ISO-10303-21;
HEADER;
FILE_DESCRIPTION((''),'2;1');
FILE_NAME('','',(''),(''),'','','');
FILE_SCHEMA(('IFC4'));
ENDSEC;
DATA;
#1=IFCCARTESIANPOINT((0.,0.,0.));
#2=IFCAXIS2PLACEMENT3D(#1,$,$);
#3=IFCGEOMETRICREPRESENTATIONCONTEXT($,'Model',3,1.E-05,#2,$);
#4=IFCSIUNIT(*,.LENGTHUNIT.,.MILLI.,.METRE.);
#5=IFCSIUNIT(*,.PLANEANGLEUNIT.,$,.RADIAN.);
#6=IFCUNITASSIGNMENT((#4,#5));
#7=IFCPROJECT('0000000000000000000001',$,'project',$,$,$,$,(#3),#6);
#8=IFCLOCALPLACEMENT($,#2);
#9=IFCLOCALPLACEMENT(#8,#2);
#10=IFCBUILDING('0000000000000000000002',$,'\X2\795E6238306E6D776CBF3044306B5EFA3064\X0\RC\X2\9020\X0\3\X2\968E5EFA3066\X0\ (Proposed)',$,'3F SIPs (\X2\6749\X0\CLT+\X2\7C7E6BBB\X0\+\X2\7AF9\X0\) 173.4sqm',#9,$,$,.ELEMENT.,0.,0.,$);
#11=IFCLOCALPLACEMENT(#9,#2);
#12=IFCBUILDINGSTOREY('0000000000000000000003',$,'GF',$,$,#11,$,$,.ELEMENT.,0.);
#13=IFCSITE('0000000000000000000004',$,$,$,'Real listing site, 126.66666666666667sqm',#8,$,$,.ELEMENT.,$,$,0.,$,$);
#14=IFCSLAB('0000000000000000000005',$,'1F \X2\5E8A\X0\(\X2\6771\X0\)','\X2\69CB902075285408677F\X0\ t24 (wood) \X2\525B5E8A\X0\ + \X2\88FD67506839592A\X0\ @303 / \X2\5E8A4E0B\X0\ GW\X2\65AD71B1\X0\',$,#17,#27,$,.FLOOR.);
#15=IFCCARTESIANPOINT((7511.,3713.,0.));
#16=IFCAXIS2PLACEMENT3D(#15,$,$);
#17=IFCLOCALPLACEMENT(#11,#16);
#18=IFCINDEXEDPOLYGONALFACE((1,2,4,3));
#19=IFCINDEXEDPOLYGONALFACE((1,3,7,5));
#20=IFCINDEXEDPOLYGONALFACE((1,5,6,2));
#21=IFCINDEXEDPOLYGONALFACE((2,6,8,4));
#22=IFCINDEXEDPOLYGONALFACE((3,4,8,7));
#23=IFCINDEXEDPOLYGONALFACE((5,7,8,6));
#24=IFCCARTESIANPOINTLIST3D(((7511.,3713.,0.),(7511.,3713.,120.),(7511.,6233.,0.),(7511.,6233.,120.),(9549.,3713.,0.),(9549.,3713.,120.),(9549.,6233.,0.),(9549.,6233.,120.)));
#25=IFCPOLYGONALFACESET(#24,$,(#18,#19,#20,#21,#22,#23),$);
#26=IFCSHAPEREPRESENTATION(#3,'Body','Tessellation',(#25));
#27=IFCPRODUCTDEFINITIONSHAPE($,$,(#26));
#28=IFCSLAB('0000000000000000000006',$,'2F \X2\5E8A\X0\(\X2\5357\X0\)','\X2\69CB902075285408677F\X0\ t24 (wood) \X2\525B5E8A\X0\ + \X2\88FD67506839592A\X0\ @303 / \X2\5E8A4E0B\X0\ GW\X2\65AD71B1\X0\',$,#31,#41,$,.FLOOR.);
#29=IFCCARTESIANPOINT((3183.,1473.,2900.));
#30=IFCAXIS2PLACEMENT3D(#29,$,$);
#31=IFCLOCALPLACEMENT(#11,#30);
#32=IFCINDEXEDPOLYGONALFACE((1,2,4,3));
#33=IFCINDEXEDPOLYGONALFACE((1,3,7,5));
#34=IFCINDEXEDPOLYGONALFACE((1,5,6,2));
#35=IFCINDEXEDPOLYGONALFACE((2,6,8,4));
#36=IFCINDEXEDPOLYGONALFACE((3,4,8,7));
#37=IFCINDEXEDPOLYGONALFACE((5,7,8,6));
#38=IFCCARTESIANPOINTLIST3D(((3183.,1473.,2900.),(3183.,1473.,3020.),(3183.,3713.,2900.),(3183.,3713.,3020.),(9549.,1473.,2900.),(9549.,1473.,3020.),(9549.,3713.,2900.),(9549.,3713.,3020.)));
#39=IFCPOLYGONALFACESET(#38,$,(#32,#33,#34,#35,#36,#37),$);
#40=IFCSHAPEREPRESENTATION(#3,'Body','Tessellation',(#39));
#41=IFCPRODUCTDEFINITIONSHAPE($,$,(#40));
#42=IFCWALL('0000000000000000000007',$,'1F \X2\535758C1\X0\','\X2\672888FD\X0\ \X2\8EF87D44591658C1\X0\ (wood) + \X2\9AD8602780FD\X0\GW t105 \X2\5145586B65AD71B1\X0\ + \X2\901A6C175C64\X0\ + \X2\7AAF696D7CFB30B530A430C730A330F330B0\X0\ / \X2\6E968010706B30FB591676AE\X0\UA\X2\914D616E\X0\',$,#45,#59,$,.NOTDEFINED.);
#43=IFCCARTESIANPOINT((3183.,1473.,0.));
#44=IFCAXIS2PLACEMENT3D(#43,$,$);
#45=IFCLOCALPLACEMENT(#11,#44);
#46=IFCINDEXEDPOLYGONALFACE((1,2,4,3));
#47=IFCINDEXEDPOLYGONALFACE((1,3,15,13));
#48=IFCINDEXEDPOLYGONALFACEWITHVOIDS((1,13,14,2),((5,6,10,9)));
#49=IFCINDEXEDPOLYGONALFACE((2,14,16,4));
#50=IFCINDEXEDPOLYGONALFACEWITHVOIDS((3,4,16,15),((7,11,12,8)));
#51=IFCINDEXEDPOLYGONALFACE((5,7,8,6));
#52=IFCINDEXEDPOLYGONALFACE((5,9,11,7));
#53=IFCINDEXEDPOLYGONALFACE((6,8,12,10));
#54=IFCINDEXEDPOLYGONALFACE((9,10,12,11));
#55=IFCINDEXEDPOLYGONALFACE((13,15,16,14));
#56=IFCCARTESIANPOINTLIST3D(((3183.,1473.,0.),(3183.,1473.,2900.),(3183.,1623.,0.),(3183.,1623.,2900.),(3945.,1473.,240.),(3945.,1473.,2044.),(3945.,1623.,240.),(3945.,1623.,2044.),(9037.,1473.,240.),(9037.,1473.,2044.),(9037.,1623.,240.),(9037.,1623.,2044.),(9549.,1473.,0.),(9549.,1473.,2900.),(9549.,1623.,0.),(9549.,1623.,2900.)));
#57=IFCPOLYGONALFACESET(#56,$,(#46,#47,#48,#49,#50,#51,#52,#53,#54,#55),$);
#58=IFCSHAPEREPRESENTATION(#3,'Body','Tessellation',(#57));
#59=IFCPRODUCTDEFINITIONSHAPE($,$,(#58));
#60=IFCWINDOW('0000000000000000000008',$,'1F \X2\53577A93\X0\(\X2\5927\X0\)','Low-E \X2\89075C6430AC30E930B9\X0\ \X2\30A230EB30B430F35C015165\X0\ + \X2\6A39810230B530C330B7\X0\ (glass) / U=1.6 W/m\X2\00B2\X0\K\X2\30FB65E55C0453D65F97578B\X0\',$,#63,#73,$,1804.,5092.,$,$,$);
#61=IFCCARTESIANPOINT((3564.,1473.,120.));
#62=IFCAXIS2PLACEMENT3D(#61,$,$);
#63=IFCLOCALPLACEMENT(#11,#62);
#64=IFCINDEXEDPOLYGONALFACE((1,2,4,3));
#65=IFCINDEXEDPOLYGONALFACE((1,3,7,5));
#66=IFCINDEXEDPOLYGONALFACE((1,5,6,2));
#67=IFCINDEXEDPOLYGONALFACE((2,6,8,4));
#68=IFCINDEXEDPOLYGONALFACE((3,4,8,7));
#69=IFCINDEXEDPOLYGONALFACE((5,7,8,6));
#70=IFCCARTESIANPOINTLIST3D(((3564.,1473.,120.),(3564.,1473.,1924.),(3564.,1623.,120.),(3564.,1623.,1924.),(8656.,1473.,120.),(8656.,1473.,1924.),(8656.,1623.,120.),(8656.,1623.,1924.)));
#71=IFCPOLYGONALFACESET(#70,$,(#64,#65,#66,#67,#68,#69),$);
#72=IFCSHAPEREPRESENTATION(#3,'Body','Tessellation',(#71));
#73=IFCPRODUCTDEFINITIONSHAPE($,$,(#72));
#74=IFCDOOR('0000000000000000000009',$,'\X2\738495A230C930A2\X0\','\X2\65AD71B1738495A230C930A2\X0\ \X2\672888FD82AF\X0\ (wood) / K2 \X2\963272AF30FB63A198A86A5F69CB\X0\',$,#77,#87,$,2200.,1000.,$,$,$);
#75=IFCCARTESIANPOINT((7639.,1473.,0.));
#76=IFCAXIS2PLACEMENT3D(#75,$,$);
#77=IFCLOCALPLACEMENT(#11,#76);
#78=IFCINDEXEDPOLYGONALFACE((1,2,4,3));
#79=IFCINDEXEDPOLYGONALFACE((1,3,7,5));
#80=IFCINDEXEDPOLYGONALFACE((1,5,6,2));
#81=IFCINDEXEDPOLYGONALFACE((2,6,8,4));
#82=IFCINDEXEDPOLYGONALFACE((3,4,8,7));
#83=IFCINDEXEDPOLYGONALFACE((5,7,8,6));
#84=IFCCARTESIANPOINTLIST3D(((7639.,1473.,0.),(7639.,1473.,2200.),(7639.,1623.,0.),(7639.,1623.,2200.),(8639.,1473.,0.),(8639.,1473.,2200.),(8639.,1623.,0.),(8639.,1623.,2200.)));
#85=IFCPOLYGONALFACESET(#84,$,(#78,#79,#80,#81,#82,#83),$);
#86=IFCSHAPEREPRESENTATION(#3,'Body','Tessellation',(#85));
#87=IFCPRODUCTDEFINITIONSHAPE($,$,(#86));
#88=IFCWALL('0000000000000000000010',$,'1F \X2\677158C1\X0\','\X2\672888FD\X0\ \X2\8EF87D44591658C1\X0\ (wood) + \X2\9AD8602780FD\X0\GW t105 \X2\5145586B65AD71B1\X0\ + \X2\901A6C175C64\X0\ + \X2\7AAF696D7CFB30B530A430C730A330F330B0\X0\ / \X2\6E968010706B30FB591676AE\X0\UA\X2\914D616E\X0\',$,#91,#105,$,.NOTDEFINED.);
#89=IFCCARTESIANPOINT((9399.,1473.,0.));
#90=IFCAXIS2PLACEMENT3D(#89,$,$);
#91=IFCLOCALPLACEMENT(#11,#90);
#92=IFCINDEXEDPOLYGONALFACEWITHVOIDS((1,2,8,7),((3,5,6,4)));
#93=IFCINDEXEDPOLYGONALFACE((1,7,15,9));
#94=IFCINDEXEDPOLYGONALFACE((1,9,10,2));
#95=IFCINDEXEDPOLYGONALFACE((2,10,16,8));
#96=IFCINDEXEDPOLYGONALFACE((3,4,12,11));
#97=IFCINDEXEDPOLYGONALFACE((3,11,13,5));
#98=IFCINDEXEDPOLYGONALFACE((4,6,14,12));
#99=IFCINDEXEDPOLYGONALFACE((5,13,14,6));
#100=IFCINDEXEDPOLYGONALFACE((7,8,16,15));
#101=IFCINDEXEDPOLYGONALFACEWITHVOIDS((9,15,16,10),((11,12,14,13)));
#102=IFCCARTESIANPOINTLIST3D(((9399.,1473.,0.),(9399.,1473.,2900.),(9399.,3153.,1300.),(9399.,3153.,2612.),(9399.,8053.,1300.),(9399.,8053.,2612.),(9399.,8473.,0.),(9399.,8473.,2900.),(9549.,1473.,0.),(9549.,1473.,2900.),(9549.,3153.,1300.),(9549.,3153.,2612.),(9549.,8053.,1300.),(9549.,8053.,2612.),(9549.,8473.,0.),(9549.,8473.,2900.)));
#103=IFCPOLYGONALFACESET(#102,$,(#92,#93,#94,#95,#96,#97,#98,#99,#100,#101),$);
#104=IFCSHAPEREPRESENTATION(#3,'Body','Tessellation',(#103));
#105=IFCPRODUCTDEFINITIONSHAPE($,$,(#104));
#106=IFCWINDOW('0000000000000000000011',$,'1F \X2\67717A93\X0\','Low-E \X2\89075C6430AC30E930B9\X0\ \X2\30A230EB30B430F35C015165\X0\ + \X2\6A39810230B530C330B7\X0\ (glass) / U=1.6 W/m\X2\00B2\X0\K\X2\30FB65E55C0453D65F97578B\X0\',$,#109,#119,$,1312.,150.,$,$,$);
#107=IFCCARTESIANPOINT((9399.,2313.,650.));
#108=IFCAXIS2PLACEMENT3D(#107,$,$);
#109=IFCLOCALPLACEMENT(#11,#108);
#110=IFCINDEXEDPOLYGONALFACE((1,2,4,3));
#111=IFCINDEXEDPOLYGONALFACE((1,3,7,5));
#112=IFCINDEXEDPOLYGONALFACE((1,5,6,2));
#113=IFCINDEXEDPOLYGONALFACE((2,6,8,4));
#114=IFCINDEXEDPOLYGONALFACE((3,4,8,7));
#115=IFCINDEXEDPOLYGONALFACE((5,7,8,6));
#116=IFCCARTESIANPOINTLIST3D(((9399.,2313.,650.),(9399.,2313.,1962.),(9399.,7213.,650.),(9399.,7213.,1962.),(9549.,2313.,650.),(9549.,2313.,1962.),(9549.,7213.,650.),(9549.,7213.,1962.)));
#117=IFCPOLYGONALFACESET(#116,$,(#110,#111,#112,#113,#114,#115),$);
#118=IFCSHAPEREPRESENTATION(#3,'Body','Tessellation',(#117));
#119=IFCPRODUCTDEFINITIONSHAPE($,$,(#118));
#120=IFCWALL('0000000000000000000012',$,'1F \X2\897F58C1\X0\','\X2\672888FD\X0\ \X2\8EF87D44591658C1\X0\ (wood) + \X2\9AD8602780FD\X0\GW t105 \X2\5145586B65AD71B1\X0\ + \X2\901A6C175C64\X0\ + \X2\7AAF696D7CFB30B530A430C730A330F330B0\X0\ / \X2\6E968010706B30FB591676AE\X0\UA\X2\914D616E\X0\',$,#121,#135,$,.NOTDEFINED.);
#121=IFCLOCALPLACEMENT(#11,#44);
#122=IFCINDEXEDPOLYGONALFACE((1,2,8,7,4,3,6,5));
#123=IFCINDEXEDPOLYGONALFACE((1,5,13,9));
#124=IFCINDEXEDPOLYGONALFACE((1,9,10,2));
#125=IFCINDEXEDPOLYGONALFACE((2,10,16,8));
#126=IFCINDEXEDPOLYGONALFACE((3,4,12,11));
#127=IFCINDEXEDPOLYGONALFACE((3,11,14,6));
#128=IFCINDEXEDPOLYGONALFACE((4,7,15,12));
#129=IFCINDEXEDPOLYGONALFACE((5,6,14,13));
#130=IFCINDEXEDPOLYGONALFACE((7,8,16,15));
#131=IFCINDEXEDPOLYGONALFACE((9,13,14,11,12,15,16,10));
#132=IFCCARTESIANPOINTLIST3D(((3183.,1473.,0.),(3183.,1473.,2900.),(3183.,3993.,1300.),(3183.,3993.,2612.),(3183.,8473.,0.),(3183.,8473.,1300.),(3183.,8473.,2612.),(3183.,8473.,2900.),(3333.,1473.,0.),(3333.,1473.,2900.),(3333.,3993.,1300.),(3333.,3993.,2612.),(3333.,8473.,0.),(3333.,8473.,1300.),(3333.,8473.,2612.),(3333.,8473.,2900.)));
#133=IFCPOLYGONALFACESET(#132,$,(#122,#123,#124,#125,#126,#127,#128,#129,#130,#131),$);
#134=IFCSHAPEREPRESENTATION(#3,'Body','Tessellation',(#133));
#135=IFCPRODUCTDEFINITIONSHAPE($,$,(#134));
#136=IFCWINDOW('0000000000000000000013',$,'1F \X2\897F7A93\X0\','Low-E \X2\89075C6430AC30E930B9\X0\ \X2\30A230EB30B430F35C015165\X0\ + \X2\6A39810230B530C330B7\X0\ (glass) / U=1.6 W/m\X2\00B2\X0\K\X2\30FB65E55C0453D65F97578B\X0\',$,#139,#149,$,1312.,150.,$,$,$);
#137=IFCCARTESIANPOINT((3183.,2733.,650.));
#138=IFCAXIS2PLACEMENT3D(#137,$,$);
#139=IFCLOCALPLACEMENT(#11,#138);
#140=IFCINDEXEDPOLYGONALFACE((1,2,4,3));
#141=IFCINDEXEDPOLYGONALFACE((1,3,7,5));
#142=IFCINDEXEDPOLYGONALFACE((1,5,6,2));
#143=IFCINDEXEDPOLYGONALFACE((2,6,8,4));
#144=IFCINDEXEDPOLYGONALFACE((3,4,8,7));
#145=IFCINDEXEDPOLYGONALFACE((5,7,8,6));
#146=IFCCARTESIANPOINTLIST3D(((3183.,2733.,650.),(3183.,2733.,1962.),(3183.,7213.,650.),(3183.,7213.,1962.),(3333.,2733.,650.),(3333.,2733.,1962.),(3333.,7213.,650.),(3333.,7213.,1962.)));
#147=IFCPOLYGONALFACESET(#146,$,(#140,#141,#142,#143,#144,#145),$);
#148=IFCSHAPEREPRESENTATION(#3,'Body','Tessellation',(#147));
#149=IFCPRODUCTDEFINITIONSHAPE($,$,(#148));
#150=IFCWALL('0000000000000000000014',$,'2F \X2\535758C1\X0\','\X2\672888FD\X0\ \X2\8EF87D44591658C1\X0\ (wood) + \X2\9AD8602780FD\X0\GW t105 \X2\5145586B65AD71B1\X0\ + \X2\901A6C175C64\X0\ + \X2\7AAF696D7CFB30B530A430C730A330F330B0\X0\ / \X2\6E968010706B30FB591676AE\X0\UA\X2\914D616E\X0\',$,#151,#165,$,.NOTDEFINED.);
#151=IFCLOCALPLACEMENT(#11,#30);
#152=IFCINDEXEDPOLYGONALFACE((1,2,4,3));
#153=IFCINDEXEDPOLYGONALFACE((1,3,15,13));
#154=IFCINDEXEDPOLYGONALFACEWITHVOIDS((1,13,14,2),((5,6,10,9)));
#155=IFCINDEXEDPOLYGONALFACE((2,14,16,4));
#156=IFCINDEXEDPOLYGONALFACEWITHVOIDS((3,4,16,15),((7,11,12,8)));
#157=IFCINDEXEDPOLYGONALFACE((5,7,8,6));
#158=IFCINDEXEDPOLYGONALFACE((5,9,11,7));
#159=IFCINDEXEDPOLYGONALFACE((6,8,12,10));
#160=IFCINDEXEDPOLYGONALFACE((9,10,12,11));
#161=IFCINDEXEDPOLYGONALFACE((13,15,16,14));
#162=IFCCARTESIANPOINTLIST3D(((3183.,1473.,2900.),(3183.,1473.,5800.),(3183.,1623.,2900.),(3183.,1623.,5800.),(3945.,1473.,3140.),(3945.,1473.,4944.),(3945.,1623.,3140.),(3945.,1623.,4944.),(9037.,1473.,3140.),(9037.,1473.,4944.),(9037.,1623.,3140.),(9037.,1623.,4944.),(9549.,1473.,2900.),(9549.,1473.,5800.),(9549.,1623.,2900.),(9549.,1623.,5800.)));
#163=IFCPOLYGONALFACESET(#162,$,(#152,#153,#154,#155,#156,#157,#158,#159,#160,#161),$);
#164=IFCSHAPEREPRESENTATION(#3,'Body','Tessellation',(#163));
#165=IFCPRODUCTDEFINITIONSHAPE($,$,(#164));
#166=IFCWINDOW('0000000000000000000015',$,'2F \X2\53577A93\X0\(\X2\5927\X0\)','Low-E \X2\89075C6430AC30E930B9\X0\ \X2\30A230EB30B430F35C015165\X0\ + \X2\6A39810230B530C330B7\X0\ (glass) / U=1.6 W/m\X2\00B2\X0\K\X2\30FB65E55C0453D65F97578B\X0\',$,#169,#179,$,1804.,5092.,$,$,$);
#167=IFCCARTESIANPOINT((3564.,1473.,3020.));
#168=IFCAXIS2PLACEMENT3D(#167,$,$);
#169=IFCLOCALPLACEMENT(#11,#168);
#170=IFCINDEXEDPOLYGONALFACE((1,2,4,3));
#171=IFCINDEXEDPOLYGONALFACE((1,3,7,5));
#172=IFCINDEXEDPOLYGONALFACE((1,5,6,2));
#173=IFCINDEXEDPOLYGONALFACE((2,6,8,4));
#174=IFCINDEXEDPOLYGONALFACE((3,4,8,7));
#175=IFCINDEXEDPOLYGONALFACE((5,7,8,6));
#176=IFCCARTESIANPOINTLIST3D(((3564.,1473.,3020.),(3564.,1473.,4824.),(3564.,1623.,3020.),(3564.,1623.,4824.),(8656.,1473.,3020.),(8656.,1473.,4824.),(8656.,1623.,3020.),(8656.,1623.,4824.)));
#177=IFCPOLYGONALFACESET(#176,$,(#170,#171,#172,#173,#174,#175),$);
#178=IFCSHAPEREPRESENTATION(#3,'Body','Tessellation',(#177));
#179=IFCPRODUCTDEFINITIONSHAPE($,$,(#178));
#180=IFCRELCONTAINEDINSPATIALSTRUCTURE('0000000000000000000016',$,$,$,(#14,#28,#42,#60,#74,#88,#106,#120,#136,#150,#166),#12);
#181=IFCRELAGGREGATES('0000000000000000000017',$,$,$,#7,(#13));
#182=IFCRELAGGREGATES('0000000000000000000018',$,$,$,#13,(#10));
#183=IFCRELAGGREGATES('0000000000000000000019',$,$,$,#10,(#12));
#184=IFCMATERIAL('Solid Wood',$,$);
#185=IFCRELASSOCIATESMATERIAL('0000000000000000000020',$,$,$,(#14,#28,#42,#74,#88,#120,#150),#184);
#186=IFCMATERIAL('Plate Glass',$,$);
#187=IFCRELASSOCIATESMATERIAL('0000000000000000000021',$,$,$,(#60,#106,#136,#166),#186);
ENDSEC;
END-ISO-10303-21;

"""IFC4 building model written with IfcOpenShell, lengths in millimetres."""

from ifc_helpers import new_model, si_unit, frame, frame_2d, origin, place, context, project, spatial, rectangle, extrude, material, element, fill, save


model = new_model("IFC4")

# Units and contexts
model_context = context("Model", 3, precision=1e-05, world=origin())
ifc_project = project(units=[si_unit("LENGTHUNIT", "METRE", prefix="MILLI"), si_unit("PLANEANGLEUNIT", "RADIAN")], contexts=[model_context])

# Site, building, storey
site_placement = place(None, origin())
site = spatial("IfcSite", under=ifc_project, at=site_placement, ObjectType="Real listing site, 126.66666666666667sqm", CompositionType="ELEMENT", RefElevation=0.0)
building_placement = place(site_placement, origin())
building = spatial("IfcBuilding", under=site, at=building_placement, Name="神戸の海沿いに建つRC造3階建て (Proposed)", ObjectType="3F SIPs (杉CLT+籾殻+竹) 173.4sqm", CompositionType="ELEMENT", ElevationOfRefHeight=0.0, ElevationOfTerrain=0.0)
storey_placement = place(building_placement, origin())
storey = spatial("IfcBuildingStorey", under=building, at=storey_placement, Name="GF", CompositionType="ELEMENT", Elevation=0.0)

# Slabs
ifc_material_1 = material(Name="Solid Wood")
slab_1_placement = place(storey_placement, frame((7511.0, 3713.0, 0.0)))
element("IfcSlab", 1, at=slab_1_placement, inside=storey, material=ifc_material_1, Name="1F 床(東)", Description="構造用合板 t24 (wood) 剛床 + 製材根太 @303 / 床下 GW断熱", PredefinedType="FLOOR", context=model_context, shape_type="SweptSolid", body=[
    extrude(rectangle(XDim=2038.0, YDim=2520.0, at=frame_2d((1019.0, 1260.0))), frame((7511.0, 3713.0, 0.0)), (0.0, 0.0, 1.0), 120.0),
])
slab_2_placement = place(storey_placement, frame((3183.0, 1473.0, 2900.0)))
element("IfcSlab", 2, at=slab_2_placement, inside=storey, material=ifc_material_1, Name="2F 床(南)", Description="構造用合板 t24 (wood) 剛床 + 製材根太 @303 / 床下 GW断熱", PredefinedType="FLOOR", context=model_context, shape_type="SweptSolid", body=[
    extrude(rectangle(XDim=6366.0, YDim=2240.0, at=frame_2d((3183.0, 1120.0))), frame((3183.0, 1473.0, 2900.0)), (0.0, 0.0, 1.0), 120.0),
])

# Wall, openings, window, door
wall_1_placement = place(storey_placement, frame((3183.0, 1473.0, 0.0)))
wall_1 = element("IfcWall", 3, at=wall_1_placement, inside=storey, material=ifc_material_1, Name="1F 南壁", Description="木製 軸組外壁 (wood) + 高性能GW t105 充填断熱 + 通気層 + 窯業系サイディング / 準耐火・外皮UA配慮", PredefinedType="NOTDEFINED", context=model_context, shape_type="SweptSolid", body=[
    extrude(rectangle(XDim=6366.0, YDim=150.0, at=frame_2d((3183.0, 75.0))), frame((3183.0, 1473.0, 0.0)), (0.0, 0.0, 1.0), 2900.0),
])
opening_1_placement = place(storey_placement, frame((3564.0, 1473.0, 120.0)))
opening_1 = element("IfcOpeningElement", 4, at=opening_1_placement, cuts=wall_1, PredefinedType="NOTDEFINED", context=model_context, shape_type="SweptSolid", body=[
    extrude(rectangle(XDim=5092.0, YDim=150.0, at=frame_2d((2546.0, 75.0))), frame((3564.0, 1473.0, 120.0)), (0.0, 0.0, 1.0), 1804.0),
])
opening_2_placement = place(storey_placement, frame((7639.0, 1473.0, 0.0)))
opening_2 = element("IfcOpeningElement", 5, at=opening_2_placement, cuts=wall_1, PredefinedType="NOTDEFINED", context=model_context, shape_type="SweptSolid", body=[
    extrude(rectangle(XDim=1000.0, YDim=150.0, at=frame_2d((500.0, 75.0))), frame((7639.0, 1473.0, 0.0)), (0.0, 0.0, 1.0), 2200.0),
])
ifc_material_2 = material(Name="Plate Glass")
window_1_placement = place(storey_placement, frame((3564.0, 1473.0, 120.0)))
window_1 = element("IfcWindow", 6, at=window_1_placement, inside=storey, material=ifc_material_2, Name="1F 南窓(大)", Description="Low-E 複層ガラス アルゴン封入 + 樹脂サッシ (glass) / U=1.6 W/m²K・日射取得型", OverallHeight=1804.0, OverallWidth=5092.0, context=model_context, shape_type="SweptSolid", body=[
    extrude(rectangle(XDim=5092.0, YDim=150.0, at=frame_2d((2546.0, 75.0))), frame((3564.0, 1473.0, 120.0)), (0.0, 0.0, 1.0), 1804.0),
])
fill(opening_1, window_1)
door_placement = place(storey_placement, frame((7639.0, 1473.0, 0.0)))
door = element("IfcDoor", 7, at=door_placement, inside=storey, material=ifc_material_1, Name="玄関ドア", Description="断熱玄関ドア 木製芯 (wood) / K2 防犯・採風機構", OverallHeight=2200.0, OverallWidth=1000.0, context=model_context, shape_type="SweptSolid", body=[
    extrude(rectangle(XDim=1000.0, YDim=150.0, at=frame_2d((500.0, 75.0))), frame((7639.0, 1473.0, 0.0)), (0.0, 0.0, 1.0), 2200.0),
])
fill(opening_2, door)

# Walls, openings, windows
wall_2_placement = place(storey_placement, frame((9399.0, 1473.0, 0.0)))
wall_2 = element("IfcWall", 8, at=wall_2_placement, inside=storey, material=ifc_material_1, Name="1F 東壁", Description="木製 軸組外壁 (wood) + 高性能GW t105 充填断熱 + 通気層 + 窯業系サイディング / 準耐火・外皮UA配慮", PredefinedType="NOTDEFINED", context=model_context, shape_type="SweptSolid", body=[
    extrude(rectangle(XDim=150.0, YDim=7000.0, at=frame_2d((75.0, 3500.0))), frame((9399.0, 1473.0, 0.0)), (0.0, 0.0, 1.0), 2900.0),
])
opening_3_placement = place(storey_placement, frame((9399.0, 2313.0, 650.0)))
opening_3 = element("IfcOpeningElement", 9, at=opening_3_placement, cuts=wall_2, PredefinedType="NOTDEFINED", context=model_context, shape_type="SweptSolid", body=[
    extrude(rectangle(XDim=150.0, YDim=4900.0, at=frame_2d((75.0, 2450.0))), frame((9399.0, 2313.0, 650.0)), (0.0, 0.0, 1.0), 1312.0),
])
window_2_placement = place(storey_placement, frame((9399.0, 2313.0, 650.0)))
window_2 = element("IfcWindow", 10, at=window_2_placement, inside=storey, material=ifc_material_2, Name="1F 東窓", Description="Low-E 複層ガラス アルゴン封入 + 樹脂サッシ (glass) / U=1.6 W/m²K・日射取得型", OverallHeight=1312.0, OverallWidth=150.0, context=model_context, shape_type="SweptSolid", body=[
    extrude(rectangle(XDim=150.0, YDim=4900.0, at=frame_2d((75.0, 2450.0))), frame((9399.0, 2313.0, 650.0)), (0.0, 0.0, 1.0), 1312.0),
])
fill(opening_3, window_2)
wall_3_placement = place(storey_placement, frame((3183.0, 1473.0, 0.0)))
wall_3 = element("IfcWall", 11, at=wall_3_placement, inside=storey, material=ifc_material_1, Name="1F 西壁", Description="木製 軸組外壁 (wood) + 高性能GW t105 充填断熱 + 通気層 + 窯業系サイディング / 準耐火・外皮UA配慮", PredefinedType="NOTDEFINED", context=model_context, shape_type="SweptSolid", body=[
    extrude(rectangle(XDim=150.0, YDim=7000.0, at=frame_2d((75.0, 3500.0))), frame((3183.0, 1473.0, 0.0)), (0.0, 0.0, 1.0), 2900.0),
])
opening_4_placement = place(storey_placement, frame((3183.0, 2733.0, 650.0)))
opening_4 = element("IfcOpeningElement", 12, at=opening_4_placement, cuts=wall_3, PredefinedType="NOTDEFINED", context=model_context, shape_type="SweptSolid", body=[
    extrude(rectangle(XDim=150.0, YDim=4480.0, at=frame_2d((75.0, 2240.0))), frame((3183.0, 2733.0, 650.0)), (0.0, 0.0, 1.0), 1312.0),
])
window_3_placement = place(storey_placement, frame((3183.0, 2733.0, 650.0)))
window_3 = element("IfcWindow", 13, at=window_3_placement, inside=storey, material=ifc_material_2, Name="1F 西窓", Description="Low-E 複層ガラス アルゴン封入 + 樹脂サッシ (glass) / U=1.6 W/m²K・日射取得型", OverallHeight=1312.0, OverallWidth=150.0, context=model_context, shape_type="SweptSolid", body=[
    extrude(rectangle(XDim=150.0, YDim=4480.0, at=frame_2d((75.0, 2240.0))), frame((3183.0, 2733.0, 650.0)), (0.0, 0.0, 1.0), 1312.0),
])
fill(opening_4, window_3)
wall_4_placement = place(storey_placement, frame((3183.0, 1473.0, 2900.0)))
wall_4 = element("IfcWall", 14, at=wall_4_placement, inside=storey, material=ifc_material_1, Name="2F 南壁", Description="木製 軸組外壁 (wood) + 高性能GW t105 充填断熱 + 通気層 + 窯業系サイディング / 準耐火・外皮UA配慮", PredefinedType="NOTDEFINED", context=model_context, shape_type="SweptSolid", body=[
    extrude(rectangle(XDim=6366.0, YDim=150.0, at=frame_2d((3183.0, 75.0))), frame((3183.0, 1473.0, 2900.0)), (0.0, 0.0, 1.0), 2900.0),
])
opening_5_placement = place(storey_placement, frame((3564.0, 1473.0, 3020.0)))
opening_5 = element("IfcOpeningElement", 15, at=opening_5_placement, cuts=wall_4, PredefinedType="NOTDEFINED", context=model_context, shape_type="SweptSolid", body=[
    extrude(rectangle(XDim=5092.0, YDim=150.0, at=frame_2d((2546.0, 75.0))), frame((3564.0, 1473.0, 3020.0)), (0.0, 0.0, 1.0), 1804.0),
])
window_4_placement = place(storey_placement, frame((3564.0, 1473.0, 3020.0)))
window_4 = element("IfcWindow", 16, at=window_4_placement, inside=storey, material=ifc_material_2, Name="2F 南窓(大)", Description="Low-E 複層ガラス アルゴン封入 + 樹脂サッシ (glass) / U=1.6 W/m²K・日射取得型", OverallHeight=1804.0, OverallWidth=5092.0, context=model_context, shape_type="SweptSolid", body=[
    extrude(rectangle(XDim=5092.0, YDim=150.0, at=frame_2d((2546.0, 75.0))), frame((3564.0, 1473.0, 3020.0)), (0.0, 0.0, 1.0), 1804.0),
])
fill(opening_5, window_4)

save(model, "model.ifc")
